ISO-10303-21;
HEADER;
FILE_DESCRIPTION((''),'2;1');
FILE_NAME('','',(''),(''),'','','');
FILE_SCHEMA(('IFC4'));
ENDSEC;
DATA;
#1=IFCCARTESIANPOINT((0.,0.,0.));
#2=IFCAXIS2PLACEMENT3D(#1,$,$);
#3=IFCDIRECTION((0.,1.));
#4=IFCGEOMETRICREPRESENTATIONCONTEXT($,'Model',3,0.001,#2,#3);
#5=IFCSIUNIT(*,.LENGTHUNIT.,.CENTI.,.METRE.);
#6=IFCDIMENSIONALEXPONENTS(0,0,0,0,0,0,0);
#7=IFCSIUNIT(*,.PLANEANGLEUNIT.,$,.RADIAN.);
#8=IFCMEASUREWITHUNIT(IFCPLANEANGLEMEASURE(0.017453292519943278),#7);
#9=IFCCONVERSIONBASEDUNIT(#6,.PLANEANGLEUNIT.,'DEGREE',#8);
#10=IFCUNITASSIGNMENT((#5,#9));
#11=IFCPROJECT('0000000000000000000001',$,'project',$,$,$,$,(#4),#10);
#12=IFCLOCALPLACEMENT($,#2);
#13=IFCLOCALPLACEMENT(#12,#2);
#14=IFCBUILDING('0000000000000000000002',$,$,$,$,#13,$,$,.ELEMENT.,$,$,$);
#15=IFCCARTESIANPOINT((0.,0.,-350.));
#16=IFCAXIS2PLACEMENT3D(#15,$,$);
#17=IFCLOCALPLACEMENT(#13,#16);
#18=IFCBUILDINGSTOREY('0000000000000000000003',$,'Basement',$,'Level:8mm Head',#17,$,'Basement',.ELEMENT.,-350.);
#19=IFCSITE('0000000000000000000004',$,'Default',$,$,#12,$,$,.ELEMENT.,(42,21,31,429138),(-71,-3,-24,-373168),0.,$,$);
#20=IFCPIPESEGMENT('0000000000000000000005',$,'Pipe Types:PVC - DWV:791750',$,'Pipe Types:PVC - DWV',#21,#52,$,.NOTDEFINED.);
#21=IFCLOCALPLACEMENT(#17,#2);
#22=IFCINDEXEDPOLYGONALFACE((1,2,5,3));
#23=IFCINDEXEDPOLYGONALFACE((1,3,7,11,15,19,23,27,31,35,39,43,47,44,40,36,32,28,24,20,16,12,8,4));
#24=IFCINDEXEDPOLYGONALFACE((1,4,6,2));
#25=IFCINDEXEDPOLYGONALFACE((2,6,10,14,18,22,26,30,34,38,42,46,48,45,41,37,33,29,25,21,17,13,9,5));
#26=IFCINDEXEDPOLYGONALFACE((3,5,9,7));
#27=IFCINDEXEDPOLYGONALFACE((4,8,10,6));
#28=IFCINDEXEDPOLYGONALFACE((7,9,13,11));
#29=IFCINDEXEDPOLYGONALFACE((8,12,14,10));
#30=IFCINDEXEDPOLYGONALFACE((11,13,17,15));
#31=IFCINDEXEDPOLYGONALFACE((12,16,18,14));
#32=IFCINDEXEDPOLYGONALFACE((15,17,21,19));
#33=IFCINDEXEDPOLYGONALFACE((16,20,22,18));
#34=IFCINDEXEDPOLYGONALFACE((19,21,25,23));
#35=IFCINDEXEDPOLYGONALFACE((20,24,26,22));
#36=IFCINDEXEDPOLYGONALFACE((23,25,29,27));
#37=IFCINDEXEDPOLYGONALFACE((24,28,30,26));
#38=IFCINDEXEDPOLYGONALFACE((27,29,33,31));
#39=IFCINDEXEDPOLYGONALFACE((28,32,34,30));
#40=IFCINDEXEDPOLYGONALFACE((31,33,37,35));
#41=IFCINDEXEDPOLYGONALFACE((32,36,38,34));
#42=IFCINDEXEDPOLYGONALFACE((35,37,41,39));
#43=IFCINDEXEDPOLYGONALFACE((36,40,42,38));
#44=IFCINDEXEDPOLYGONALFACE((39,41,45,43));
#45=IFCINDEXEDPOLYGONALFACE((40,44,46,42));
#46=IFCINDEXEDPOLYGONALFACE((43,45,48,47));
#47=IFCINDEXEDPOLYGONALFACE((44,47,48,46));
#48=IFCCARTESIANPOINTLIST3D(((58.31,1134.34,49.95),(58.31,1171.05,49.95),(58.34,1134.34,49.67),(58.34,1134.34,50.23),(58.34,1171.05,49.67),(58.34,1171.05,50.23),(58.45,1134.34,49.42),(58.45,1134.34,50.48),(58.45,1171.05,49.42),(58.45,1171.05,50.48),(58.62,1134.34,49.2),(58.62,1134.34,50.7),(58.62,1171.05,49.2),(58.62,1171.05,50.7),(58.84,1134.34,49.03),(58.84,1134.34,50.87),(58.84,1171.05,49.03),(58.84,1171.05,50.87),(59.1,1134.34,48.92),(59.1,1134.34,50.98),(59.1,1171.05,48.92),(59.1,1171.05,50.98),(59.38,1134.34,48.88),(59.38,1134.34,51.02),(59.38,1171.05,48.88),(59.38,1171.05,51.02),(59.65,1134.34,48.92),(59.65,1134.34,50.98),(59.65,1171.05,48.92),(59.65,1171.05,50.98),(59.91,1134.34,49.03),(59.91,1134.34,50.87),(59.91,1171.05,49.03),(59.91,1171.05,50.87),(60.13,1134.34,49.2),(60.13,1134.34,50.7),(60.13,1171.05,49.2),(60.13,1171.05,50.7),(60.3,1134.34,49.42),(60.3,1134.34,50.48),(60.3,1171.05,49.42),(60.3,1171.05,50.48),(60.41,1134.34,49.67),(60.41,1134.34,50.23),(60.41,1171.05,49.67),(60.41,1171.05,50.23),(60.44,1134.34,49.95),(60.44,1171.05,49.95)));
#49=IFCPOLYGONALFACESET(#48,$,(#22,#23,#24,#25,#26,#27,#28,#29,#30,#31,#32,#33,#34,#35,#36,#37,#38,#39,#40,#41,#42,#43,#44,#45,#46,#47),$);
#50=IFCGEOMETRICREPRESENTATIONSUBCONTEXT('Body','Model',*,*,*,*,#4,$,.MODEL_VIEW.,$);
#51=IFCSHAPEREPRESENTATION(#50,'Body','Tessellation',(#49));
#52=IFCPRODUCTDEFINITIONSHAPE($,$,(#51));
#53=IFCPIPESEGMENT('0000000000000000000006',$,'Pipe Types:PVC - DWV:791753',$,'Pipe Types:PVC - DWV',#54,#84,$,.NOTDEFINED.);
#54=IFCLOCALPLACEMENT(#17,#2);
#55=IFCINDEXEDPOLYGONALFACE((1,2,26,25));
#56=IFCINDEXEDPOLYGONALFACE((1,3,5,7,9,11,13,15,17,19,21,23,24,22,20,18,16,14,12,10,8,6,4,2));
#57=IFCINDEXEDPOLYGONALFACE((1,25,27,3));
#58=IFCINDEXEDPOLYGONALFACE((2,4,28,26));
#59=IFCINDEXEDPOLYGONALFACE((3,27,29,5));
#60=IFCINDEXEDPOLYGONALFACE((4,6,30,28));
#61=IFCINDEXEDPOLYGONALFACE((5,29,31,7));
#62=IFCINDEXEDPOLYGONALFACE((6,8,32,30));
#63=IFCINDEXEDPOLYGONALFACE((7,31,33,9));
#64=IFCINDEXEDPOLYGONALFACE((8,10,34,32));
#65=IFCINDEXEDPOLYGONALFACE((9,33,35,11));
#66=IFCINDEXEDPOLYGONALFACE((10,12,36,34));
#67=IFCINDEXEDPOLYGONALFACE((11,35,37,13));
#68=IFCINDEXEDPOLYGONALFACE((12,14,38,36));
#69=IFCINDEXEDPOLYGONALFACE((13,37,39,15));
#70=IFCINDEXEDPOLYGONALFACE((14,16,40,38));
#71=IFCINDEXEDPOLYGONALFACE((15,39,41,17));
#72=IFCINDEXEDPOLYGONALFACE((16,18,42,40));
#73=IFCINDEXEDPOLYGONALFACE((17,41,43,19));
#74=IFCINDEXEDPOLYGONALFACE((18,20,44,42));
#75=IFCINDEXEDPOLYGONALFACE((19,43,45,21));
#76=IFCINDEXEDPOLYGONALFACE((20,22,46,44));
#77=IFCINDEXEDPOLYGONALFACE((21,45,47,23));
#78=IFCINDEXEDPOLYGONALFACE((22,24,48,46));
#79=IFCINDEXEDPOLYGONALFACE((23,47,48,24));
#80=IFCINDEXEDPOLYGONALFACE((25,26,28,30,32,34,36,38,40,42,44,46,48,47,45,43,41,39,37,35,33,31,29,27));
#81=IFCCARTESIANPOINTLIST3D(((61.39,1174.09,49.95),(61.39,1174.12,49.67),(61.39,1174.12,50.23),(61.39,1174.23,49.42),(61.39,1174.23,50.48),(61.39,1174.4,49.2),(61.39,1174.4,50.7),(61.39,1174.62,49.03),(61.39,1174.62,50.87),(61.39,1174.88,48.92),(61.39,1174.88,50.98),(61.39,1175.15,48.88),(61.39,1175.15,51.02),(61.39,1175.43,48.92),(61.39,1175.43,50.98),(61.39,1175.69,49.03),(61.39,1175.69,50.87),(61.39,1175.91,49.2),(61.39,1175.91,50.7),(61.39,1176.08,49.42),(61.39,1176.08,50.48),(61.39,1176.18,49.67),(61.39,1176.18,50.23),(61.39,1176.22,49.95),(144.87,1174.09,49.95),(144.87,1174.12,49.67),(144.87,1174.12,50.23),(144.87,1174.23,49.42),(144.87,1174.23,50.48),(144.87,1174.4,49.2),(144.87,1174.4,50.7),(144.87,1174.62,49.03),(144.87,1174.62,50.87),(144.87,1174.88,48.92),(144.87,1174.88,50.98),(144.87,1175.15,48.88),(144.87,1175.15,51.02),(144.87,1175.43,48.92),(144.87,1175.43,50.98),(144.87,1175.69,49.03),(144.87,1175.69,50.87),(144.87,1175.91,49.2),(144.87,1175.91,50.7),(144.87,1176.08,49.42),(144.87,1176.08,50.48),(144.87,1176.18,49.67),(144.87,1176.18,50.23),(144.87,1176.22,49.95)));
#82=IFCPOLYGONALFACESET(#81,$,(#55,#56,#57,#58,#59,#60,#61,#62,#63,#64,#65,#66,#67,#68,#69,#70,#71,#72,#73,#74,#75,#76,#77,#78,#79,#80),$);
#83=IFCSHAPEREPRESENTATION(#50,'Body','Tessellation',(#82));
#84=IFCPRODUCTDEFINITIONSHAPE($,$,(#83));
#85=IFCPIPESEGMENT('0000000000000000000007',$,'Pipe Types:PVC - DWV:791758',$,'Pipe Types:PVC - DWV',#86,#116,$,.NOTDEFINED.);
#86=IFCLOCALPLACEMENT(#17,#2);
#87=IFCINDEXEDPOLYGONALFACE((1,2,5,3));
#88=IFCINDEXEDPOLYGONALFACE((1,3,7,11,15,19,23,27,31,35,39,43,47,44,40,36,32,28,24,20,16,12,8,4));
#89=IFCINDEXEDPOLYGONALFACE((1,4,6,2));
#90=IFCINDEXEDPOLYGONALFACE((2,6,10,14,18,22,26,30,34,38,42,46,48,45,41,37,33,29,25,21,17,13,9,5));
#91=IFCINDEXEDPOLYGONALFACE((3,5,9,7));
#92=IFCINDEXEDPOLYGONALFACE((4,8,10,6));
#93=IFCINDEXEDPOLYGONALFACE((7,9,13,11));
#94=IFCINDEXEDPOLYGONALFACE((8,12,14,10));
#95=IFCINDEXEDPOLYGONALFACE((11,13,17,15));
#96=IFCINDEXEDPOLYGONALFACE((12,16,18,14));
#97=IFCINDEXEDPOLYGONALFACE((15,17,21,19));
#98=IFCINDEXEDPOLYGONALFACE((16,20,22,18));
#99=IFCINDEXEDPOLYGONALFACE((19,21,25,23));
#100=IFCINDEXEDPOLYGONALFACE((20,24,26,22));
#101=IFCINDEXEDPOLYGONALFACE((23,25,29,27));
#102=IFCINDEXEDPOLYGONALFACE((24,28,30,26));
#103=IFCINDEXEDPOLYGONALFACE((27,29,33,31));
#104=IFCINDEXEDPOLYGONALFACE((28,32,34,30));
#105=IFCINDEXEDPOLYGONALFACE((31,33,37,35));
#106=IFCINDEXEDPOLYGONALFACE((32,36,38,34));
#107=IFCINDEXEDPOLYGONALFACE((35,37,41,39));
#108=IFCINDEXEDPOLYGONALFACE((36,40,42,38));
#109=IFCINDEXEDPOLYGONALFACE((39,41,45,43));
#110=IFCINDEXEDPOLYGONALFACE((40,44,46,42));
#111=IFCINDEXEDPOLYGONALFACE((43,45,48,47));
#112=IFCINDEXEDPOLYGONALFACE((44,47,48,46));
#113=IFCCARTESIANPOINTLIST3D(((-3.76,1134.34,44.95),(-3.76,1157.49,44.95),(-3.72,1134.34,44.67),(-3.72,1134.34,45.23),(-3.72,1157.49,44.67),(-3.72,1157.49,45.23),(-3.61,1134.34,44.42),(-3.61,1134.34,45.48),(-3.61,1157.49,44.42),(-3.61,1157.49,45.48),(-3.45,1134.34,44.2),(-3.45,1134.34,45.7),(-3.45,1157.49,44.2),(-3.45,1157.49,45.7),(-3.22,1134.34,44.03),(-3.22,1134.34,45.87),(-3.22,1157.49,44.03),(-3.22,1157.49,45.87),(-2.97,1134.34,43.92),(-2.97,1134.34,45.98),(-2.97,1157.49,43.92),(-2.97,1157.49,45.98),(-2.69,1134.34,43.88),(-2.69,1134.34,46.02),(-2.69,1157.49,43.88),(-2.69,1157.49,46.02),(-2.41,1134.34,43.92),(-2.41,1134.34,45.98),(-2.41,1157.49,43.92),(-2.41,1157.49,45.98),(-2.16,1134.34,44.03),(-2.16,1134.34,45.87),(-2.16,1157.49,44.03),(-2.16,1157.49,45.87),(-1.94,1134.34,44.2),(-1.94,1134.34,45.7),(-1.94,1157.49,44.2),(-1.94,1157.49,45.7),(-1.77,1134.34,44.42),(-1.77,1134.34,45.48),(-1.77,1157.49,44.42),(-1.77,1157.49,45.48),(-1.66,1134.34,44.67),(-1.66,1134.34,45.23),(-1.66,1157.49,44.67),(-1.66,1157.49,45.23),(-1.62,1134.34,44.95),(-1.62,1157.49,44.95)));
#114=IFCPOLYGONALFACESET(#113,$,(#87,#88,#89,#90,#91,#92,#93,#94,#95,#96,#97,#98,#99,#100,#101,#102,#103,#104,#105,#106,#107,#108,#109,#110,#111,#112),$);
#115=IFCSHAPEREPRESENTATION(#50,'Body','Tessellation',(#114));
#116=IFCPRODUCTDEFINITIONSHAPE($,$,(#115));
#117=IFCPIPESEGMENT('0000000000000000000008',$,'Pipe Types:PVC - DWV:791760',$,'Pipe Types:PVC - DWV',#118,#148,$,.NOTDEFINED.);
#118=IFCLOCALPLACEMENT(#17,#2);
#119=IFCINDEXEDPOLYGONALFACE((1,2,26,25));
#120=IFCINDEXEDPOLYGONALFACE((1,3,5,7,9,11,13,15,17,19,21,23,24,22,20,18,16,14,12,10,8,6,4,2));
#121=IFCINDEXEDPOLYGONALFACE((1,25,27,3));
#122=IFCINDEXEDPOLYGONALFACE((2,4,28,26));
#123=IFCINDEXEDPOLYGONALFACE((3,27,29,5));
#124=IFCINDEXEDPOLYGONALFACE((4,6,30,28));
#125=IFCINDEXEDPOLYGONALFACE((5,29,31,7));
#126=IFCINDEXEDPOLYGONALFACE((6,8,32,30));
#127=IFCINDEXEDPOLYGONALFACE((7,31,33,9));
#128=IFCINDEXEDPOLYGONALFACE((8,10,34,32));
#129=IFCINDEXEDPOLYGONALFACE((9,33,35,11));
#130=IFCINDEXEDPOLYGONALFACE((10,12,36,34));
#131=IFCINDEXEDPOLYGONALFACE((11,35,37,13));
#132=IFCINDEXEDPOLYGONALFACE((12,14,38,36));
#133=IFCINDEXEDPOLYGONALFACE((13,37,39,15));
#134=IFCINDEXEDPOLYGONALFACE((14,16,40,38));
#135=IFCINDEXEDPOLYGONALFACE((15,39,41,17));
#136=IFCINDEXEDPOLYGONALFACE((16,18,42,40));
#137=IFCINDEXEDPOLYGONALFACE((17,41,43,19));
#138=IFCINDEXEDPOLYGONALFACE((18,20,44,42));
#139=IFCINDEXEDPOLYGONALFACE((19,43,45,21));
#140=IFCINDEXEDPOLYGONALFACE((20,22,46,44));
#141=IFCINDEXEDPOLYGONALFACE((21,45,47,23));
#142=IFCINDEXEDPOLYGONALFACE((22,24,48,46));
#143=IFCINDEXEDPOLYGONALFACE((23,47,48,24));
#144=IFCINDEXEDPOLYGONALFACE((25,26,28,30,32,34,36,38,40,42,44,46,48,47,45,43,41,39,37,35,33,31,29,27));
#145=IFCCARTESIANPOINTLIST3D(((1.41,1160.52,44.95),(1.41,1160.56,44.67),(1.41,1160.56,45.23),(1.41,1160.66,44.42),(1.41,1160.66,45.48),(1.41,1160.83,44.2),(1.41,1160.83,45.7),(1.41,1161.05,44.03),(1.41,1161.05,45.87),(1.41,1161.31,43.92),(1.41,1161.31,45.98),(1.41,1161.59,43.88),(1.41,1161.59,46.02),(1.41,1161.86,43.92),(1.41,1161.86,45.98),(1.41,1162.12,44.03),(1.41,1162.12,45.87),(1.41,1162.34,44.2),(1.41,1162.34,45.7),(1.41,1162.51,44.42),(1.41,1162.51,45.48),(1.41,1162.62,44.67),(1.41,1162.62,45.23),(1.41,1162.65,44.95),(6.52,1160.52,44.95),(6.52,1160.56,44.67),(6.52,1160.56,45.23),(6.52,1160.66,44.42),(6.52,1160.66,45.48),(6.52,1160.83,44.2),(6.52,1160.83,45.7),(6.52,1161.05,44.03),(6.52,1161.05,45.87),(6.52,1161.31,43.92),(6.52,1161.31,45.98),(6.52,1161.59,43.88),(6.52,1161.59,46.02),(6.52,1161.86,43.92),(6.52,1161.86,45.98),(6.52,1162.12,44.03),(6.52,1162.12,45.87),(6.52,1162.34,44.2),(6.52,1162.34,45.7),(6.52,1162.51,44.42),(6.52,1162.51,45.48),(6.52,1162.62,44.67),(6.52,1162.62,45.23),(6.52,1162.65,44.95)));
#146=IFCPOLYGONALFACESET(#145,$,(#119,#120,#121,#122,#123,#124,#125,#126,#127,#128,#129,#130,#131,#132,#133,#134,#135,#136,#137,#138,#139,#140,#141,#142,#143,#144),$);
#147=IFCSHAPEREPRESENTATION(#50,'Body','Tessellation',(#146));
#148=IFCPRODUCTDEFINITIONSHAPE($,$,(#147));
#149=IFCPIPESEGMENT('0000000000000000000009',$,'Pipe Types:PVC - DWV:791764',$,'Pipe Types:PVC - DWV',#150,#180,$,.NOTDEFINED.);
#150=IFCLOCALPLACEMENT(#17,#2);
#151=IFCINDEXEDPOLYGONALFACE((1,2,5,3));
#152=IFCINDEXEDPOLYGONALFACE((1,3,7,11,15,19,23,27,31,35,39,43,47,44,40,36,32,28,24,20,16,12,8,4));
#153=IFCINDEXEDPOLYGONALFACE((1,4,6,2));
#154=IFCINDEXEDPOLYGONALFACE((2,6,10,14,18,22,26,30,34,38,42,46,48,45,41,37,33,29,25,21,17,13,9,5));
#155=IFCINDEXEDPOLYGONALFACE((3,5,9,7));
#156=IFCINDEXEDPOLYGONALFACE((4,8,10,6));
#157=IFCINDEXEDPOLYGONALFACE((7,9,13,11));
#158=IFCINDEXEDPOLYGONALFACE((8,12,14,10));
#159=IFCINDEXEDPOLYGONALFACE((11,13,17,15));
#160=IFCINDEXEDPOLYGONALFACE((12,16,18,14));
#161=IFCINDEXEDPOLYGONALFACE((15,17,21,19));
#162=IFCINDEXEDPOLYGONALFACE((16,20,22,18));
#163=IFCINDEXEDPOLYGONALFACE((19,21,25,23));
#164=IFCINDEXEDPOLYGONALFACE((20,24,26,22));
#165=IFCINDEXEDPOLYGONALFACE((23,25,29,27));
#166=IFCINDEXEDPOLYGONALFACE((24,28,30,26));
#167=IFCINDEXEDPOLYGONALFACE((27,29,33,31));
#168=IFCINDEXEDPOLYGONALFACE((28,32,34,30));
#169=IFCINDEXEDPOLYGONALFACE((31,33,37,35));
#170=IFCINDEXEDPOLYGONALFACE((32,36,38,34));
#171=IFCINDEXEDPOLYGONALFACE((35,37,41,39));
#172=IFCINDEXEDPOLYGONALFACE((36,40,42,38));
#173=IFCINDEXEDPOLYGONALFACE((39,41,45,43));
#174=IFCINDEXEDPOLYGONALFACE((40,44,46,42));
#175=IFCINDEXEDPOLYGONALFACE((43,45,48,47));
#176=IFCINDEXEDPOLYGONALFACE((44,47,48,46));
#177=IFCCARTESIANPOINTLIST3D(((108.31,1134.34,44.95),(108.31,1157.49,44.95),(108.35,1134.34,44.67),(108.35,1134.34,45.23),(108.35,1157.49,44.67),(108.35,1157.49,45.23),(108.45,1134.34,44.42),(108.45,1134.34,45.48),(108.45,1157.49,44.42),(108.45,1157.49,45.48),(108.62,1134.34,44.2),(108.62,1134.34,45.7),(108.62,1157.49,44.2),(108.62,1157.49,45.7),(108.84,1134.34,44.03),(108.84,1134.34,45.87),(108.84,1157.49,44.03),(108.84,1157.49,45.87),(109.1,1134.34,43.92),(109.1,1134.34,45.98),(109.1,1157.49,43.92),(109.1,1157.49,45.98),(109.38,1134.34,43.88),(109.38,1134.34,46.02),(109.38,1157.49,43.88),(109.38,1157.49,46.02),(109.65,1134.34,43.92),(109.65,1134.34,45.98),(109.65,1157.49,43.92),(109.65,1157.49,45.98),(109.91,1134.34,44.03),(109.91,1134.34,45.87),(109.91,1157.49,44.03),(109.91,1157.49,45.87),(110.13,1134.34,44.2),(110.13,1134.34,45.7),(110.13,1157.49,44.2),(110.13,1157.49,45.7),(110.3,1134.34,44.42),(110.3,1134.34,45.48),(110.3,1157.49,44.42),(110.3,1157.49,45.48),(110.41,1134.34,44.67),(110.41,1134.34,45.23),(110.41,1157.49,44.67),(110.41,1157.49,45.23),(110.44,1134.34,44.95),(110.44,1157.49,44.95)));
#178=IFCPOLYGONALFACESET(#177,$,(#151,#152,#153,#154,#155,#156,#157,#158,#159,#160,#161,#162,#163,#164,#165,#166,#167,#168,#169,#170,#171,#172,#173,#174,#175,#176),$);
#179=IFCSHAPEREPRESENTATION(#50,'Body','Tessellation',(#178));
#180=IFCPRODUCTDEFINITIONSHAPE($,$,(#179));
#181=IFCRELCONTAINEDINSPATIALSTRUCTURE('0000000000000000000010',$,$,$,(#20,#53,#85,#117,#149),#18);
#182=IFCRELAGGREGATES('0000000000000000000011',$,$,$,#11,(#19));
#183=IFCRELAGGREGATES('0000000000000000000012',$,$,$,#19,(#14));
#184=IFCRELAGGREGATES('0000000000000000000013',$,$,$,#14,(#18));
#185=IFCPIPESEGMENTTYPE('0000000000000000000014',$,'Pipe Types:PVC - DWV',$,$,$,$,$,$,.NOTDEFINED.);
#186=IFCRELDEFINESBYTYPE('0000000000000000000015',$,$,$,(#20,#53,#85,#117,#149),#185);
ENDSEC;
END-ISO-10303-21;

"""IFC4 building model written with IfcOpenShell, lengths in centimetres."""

from ifc_helpers import new_model, entity, si_unit, converted_unit, direction, frame, origin, place, context, subcontext, project, spatial, arc, indexed_curve, outline, extrude, type_object, element, save


model = new_model("IFC4")

# Units and contexts
model_context = context("Model", 3, precision=0.001, world=origin(), true_north=direction((0.0, 1.0)))
body_context = subcontext(model_context, "Body", "Model", "MODEL_VIEW")
ifc_project = project(units=[si_unit("LENGTHUNIT", "METRE", prefix="CENTI"), converted_unit("PLANEANGLEUNIT", "DEGREE", entity("IfcPlaneAngleMeasure", 0.017453292519943278), si_unit("PLANEANGLEUNIT", "RADIAN"), dimensions=[0, 0, 0, 0, 0, 0, 0])], contexts=[model_context])

# Site, building, storey
site_placement = place(None, origin())
site = spatial("IfcSite", under=ifc_project, at=site_placement, Name="Default", CompositionType="ELEMENT", RefLatitude=(42, 21, 31, 429138), RefLongitude=(-71, -3, -24, -373168), RefElevation=0.0)
building_placement = place(site_placement, origin())
building = spatial("IfcBuilding", under=site, at=building_placement, CompositionType="ELEMENT")
storey_placement = place(building_placement, frame((0.0, 0.0, -350.0)))
storey = spatial("IfcBuildingStorey", under=building, at=storey_placement, Name="Basement", ObjectType="Level:8mm Head", LongName="Basement", CompositionType="ELEMENT", Elevation=-350.0)

# Pipe segments
pipe_segment_type = type_object("IfcPipeSegmentType", Name="Pipe Types:PVC - DWV", PredefinedType="NOTDEFINED")
pipe_segment_1_placement = place(storey_placement, origin())
element("IfcPipeSegment", 1, at=pipe_segment_1_placement, inside=storey, type_object=pipe_segment_type, Name="Pipe Types:PVC - DWV:791750", ObjectType="Pipe Types:PVC - DWV", PredefinedType="NOTDEFINED", context=body_context, shape_type="SweptSolid", body=[
    extrude(outline(indexed_curve([(1.07, 0.0), (0.75, 0.75), (0.0, 1.07), (-0.75, 0.75), (-1.07, 0.0), (-0.75, -0.75), (0.0, -1.07), (0.75, -0.75)], segments=[arc(1, 2, 3), arc(3, 4, 5), arc(5, 6, 7), arc(7, 8, 1)], self_intersect=False)), frame((59.38, 1134.34, 49.95), z_axis=(0.0, 1.0, 0.0), x_axis=(-1.0, 0.0, 0.0)), (0.0, 0.0, 1.0), 36.71),
])
pipe_segment_2_placement = place(storey_placement, origin())
element("IfcPipeSegment", 2, at=pipe_segment_2_placement, inside=storey, type_object=pipe_segment_type, Name="Pipe Types:PVC - DWV:791753", ObjectType="Pipe Types:PVC - DWV", PredefinedType="NOTDEFINED", context=body_context, shape_type="SweptSolid", body=[
    extrude(outline(indexed_curve([(1.07, 0.0), (0.75, 0.75), (0.0, 1.07), (-0.75, 0.75), (-1.07, 0.0), (-0.75, -0.75), (0.0, -1.07), (0.75, -0.75)], segments=[arc(1, 2, 3), arc(3, 4, 5), arc(5, 6, 7), arc(7, 8, 1)], self_intersect=False)), frame((61.39, 1175.15, 49.95), z_axis=(1.0, 0.0, 0.0), x_axis=(0.0, 1.0, 0.0)), (0.0, 0.0, 1.0), 83.49),
])
pipe_segment_3_placement = place(storey_placement, origin())
element("IfcPipeSegment", 3, at=pipe_segment_3_placement, inside=storey, type_object=pipe_segment_type, Name="Pipe Types:PVC - DWV:791758", ObjectType="Pipe Types:PVC - DWV", PredefinedType="NOTDEFINED", context=body_context, shape_type="SweptSolid", body=[
    extrude(outline(indexed_curve([(1.07, 0.0), (0.75, 0.75), (0.0, 1.07), (-0.75, 0.75), (-1.07, 0.0), (-0.75, -0.75), (0.0, -1.07), (0.75, -0.75)], segments=[arc(1, 2, 3), arc(3, 4, 5), arc(5, 6, 7), arc(7, 8, 1)], self_intersect=False)), frame((-2.69, 1134.34, 44.95), z_axis=(0.0, 1.0, 0.0), x_axis=(1.0, 0.0, 0.0)), (0.0, 0.0, 1.0), 23.14),
])
pipe_segment_4_placement = place(storey_placement, origin())
element("IfcPipeSegment", 4, at=pipe_segment_4_placement, inside=storey, type_object=pipe_segment_type, Name="Pipe Types:PVC - DWV:791760", ObjectType="Pipe Types:PVC - DWV", PredefinedType="NOTDEFINED", context=body_context, shape_type="SweptSolid", body=[
    extrude(outline(indexed_curve([(1.07, 0.0), (0.75, 0.75), (0.0, 1.07), (-0.75, 0.75), (-1.07, 0.0), (-0.75, -0.75), (0.0, -1.07), (0.75, -0.75)], segments=[arc(1, 2, 3), arc(3, 4, 5), arc(5, 6, 7), arc(7, 8, 1)], self_intersect=False)), frame((1.41, 1161.59, 44.95), z_axis=(1.0, 0.0, 0.0), x_axis=(0.0, -1.0, 0.0)), (0.0, 0.0, 1.0), 5.11),
])
pipe_segment_5_placement = place(storey_placement, origin())
element("IfcPipeSegment", 5, at=pipe_segment_5_placement, inside=storey, type_object=pipe_segment_type, Name="Pipe Types:PVC - DWV:791764", ObjectType="Pipe Types:PVC - DWV", PredefinedType="NOTDEFINED", context=body_context, shape_type="SweptSolid", body=[
    extrude(outline(indexed_curve([(1.07, 0.0), (0.75, 0.75), (0.0, 1.07), (-0.75, 0.75), (-1.07, 0.0), (-0.75, -0.75), (0.0, -1.07), (0.75, -0.75)], segments=[arc(1, 2, 3), arc(3, 4, 5), arc(5, 6, 7), arc(7, 8, 1)], self_intersect=False)), frame((109.38, 1134.34, 44.95), z_axis=(0.0, 1.0, 0.0), x_axis=(1.0, 0.0, 0.0)), (0.0, 0.0, 1.0), 23.14),
])

save(model, "model.ifc")
